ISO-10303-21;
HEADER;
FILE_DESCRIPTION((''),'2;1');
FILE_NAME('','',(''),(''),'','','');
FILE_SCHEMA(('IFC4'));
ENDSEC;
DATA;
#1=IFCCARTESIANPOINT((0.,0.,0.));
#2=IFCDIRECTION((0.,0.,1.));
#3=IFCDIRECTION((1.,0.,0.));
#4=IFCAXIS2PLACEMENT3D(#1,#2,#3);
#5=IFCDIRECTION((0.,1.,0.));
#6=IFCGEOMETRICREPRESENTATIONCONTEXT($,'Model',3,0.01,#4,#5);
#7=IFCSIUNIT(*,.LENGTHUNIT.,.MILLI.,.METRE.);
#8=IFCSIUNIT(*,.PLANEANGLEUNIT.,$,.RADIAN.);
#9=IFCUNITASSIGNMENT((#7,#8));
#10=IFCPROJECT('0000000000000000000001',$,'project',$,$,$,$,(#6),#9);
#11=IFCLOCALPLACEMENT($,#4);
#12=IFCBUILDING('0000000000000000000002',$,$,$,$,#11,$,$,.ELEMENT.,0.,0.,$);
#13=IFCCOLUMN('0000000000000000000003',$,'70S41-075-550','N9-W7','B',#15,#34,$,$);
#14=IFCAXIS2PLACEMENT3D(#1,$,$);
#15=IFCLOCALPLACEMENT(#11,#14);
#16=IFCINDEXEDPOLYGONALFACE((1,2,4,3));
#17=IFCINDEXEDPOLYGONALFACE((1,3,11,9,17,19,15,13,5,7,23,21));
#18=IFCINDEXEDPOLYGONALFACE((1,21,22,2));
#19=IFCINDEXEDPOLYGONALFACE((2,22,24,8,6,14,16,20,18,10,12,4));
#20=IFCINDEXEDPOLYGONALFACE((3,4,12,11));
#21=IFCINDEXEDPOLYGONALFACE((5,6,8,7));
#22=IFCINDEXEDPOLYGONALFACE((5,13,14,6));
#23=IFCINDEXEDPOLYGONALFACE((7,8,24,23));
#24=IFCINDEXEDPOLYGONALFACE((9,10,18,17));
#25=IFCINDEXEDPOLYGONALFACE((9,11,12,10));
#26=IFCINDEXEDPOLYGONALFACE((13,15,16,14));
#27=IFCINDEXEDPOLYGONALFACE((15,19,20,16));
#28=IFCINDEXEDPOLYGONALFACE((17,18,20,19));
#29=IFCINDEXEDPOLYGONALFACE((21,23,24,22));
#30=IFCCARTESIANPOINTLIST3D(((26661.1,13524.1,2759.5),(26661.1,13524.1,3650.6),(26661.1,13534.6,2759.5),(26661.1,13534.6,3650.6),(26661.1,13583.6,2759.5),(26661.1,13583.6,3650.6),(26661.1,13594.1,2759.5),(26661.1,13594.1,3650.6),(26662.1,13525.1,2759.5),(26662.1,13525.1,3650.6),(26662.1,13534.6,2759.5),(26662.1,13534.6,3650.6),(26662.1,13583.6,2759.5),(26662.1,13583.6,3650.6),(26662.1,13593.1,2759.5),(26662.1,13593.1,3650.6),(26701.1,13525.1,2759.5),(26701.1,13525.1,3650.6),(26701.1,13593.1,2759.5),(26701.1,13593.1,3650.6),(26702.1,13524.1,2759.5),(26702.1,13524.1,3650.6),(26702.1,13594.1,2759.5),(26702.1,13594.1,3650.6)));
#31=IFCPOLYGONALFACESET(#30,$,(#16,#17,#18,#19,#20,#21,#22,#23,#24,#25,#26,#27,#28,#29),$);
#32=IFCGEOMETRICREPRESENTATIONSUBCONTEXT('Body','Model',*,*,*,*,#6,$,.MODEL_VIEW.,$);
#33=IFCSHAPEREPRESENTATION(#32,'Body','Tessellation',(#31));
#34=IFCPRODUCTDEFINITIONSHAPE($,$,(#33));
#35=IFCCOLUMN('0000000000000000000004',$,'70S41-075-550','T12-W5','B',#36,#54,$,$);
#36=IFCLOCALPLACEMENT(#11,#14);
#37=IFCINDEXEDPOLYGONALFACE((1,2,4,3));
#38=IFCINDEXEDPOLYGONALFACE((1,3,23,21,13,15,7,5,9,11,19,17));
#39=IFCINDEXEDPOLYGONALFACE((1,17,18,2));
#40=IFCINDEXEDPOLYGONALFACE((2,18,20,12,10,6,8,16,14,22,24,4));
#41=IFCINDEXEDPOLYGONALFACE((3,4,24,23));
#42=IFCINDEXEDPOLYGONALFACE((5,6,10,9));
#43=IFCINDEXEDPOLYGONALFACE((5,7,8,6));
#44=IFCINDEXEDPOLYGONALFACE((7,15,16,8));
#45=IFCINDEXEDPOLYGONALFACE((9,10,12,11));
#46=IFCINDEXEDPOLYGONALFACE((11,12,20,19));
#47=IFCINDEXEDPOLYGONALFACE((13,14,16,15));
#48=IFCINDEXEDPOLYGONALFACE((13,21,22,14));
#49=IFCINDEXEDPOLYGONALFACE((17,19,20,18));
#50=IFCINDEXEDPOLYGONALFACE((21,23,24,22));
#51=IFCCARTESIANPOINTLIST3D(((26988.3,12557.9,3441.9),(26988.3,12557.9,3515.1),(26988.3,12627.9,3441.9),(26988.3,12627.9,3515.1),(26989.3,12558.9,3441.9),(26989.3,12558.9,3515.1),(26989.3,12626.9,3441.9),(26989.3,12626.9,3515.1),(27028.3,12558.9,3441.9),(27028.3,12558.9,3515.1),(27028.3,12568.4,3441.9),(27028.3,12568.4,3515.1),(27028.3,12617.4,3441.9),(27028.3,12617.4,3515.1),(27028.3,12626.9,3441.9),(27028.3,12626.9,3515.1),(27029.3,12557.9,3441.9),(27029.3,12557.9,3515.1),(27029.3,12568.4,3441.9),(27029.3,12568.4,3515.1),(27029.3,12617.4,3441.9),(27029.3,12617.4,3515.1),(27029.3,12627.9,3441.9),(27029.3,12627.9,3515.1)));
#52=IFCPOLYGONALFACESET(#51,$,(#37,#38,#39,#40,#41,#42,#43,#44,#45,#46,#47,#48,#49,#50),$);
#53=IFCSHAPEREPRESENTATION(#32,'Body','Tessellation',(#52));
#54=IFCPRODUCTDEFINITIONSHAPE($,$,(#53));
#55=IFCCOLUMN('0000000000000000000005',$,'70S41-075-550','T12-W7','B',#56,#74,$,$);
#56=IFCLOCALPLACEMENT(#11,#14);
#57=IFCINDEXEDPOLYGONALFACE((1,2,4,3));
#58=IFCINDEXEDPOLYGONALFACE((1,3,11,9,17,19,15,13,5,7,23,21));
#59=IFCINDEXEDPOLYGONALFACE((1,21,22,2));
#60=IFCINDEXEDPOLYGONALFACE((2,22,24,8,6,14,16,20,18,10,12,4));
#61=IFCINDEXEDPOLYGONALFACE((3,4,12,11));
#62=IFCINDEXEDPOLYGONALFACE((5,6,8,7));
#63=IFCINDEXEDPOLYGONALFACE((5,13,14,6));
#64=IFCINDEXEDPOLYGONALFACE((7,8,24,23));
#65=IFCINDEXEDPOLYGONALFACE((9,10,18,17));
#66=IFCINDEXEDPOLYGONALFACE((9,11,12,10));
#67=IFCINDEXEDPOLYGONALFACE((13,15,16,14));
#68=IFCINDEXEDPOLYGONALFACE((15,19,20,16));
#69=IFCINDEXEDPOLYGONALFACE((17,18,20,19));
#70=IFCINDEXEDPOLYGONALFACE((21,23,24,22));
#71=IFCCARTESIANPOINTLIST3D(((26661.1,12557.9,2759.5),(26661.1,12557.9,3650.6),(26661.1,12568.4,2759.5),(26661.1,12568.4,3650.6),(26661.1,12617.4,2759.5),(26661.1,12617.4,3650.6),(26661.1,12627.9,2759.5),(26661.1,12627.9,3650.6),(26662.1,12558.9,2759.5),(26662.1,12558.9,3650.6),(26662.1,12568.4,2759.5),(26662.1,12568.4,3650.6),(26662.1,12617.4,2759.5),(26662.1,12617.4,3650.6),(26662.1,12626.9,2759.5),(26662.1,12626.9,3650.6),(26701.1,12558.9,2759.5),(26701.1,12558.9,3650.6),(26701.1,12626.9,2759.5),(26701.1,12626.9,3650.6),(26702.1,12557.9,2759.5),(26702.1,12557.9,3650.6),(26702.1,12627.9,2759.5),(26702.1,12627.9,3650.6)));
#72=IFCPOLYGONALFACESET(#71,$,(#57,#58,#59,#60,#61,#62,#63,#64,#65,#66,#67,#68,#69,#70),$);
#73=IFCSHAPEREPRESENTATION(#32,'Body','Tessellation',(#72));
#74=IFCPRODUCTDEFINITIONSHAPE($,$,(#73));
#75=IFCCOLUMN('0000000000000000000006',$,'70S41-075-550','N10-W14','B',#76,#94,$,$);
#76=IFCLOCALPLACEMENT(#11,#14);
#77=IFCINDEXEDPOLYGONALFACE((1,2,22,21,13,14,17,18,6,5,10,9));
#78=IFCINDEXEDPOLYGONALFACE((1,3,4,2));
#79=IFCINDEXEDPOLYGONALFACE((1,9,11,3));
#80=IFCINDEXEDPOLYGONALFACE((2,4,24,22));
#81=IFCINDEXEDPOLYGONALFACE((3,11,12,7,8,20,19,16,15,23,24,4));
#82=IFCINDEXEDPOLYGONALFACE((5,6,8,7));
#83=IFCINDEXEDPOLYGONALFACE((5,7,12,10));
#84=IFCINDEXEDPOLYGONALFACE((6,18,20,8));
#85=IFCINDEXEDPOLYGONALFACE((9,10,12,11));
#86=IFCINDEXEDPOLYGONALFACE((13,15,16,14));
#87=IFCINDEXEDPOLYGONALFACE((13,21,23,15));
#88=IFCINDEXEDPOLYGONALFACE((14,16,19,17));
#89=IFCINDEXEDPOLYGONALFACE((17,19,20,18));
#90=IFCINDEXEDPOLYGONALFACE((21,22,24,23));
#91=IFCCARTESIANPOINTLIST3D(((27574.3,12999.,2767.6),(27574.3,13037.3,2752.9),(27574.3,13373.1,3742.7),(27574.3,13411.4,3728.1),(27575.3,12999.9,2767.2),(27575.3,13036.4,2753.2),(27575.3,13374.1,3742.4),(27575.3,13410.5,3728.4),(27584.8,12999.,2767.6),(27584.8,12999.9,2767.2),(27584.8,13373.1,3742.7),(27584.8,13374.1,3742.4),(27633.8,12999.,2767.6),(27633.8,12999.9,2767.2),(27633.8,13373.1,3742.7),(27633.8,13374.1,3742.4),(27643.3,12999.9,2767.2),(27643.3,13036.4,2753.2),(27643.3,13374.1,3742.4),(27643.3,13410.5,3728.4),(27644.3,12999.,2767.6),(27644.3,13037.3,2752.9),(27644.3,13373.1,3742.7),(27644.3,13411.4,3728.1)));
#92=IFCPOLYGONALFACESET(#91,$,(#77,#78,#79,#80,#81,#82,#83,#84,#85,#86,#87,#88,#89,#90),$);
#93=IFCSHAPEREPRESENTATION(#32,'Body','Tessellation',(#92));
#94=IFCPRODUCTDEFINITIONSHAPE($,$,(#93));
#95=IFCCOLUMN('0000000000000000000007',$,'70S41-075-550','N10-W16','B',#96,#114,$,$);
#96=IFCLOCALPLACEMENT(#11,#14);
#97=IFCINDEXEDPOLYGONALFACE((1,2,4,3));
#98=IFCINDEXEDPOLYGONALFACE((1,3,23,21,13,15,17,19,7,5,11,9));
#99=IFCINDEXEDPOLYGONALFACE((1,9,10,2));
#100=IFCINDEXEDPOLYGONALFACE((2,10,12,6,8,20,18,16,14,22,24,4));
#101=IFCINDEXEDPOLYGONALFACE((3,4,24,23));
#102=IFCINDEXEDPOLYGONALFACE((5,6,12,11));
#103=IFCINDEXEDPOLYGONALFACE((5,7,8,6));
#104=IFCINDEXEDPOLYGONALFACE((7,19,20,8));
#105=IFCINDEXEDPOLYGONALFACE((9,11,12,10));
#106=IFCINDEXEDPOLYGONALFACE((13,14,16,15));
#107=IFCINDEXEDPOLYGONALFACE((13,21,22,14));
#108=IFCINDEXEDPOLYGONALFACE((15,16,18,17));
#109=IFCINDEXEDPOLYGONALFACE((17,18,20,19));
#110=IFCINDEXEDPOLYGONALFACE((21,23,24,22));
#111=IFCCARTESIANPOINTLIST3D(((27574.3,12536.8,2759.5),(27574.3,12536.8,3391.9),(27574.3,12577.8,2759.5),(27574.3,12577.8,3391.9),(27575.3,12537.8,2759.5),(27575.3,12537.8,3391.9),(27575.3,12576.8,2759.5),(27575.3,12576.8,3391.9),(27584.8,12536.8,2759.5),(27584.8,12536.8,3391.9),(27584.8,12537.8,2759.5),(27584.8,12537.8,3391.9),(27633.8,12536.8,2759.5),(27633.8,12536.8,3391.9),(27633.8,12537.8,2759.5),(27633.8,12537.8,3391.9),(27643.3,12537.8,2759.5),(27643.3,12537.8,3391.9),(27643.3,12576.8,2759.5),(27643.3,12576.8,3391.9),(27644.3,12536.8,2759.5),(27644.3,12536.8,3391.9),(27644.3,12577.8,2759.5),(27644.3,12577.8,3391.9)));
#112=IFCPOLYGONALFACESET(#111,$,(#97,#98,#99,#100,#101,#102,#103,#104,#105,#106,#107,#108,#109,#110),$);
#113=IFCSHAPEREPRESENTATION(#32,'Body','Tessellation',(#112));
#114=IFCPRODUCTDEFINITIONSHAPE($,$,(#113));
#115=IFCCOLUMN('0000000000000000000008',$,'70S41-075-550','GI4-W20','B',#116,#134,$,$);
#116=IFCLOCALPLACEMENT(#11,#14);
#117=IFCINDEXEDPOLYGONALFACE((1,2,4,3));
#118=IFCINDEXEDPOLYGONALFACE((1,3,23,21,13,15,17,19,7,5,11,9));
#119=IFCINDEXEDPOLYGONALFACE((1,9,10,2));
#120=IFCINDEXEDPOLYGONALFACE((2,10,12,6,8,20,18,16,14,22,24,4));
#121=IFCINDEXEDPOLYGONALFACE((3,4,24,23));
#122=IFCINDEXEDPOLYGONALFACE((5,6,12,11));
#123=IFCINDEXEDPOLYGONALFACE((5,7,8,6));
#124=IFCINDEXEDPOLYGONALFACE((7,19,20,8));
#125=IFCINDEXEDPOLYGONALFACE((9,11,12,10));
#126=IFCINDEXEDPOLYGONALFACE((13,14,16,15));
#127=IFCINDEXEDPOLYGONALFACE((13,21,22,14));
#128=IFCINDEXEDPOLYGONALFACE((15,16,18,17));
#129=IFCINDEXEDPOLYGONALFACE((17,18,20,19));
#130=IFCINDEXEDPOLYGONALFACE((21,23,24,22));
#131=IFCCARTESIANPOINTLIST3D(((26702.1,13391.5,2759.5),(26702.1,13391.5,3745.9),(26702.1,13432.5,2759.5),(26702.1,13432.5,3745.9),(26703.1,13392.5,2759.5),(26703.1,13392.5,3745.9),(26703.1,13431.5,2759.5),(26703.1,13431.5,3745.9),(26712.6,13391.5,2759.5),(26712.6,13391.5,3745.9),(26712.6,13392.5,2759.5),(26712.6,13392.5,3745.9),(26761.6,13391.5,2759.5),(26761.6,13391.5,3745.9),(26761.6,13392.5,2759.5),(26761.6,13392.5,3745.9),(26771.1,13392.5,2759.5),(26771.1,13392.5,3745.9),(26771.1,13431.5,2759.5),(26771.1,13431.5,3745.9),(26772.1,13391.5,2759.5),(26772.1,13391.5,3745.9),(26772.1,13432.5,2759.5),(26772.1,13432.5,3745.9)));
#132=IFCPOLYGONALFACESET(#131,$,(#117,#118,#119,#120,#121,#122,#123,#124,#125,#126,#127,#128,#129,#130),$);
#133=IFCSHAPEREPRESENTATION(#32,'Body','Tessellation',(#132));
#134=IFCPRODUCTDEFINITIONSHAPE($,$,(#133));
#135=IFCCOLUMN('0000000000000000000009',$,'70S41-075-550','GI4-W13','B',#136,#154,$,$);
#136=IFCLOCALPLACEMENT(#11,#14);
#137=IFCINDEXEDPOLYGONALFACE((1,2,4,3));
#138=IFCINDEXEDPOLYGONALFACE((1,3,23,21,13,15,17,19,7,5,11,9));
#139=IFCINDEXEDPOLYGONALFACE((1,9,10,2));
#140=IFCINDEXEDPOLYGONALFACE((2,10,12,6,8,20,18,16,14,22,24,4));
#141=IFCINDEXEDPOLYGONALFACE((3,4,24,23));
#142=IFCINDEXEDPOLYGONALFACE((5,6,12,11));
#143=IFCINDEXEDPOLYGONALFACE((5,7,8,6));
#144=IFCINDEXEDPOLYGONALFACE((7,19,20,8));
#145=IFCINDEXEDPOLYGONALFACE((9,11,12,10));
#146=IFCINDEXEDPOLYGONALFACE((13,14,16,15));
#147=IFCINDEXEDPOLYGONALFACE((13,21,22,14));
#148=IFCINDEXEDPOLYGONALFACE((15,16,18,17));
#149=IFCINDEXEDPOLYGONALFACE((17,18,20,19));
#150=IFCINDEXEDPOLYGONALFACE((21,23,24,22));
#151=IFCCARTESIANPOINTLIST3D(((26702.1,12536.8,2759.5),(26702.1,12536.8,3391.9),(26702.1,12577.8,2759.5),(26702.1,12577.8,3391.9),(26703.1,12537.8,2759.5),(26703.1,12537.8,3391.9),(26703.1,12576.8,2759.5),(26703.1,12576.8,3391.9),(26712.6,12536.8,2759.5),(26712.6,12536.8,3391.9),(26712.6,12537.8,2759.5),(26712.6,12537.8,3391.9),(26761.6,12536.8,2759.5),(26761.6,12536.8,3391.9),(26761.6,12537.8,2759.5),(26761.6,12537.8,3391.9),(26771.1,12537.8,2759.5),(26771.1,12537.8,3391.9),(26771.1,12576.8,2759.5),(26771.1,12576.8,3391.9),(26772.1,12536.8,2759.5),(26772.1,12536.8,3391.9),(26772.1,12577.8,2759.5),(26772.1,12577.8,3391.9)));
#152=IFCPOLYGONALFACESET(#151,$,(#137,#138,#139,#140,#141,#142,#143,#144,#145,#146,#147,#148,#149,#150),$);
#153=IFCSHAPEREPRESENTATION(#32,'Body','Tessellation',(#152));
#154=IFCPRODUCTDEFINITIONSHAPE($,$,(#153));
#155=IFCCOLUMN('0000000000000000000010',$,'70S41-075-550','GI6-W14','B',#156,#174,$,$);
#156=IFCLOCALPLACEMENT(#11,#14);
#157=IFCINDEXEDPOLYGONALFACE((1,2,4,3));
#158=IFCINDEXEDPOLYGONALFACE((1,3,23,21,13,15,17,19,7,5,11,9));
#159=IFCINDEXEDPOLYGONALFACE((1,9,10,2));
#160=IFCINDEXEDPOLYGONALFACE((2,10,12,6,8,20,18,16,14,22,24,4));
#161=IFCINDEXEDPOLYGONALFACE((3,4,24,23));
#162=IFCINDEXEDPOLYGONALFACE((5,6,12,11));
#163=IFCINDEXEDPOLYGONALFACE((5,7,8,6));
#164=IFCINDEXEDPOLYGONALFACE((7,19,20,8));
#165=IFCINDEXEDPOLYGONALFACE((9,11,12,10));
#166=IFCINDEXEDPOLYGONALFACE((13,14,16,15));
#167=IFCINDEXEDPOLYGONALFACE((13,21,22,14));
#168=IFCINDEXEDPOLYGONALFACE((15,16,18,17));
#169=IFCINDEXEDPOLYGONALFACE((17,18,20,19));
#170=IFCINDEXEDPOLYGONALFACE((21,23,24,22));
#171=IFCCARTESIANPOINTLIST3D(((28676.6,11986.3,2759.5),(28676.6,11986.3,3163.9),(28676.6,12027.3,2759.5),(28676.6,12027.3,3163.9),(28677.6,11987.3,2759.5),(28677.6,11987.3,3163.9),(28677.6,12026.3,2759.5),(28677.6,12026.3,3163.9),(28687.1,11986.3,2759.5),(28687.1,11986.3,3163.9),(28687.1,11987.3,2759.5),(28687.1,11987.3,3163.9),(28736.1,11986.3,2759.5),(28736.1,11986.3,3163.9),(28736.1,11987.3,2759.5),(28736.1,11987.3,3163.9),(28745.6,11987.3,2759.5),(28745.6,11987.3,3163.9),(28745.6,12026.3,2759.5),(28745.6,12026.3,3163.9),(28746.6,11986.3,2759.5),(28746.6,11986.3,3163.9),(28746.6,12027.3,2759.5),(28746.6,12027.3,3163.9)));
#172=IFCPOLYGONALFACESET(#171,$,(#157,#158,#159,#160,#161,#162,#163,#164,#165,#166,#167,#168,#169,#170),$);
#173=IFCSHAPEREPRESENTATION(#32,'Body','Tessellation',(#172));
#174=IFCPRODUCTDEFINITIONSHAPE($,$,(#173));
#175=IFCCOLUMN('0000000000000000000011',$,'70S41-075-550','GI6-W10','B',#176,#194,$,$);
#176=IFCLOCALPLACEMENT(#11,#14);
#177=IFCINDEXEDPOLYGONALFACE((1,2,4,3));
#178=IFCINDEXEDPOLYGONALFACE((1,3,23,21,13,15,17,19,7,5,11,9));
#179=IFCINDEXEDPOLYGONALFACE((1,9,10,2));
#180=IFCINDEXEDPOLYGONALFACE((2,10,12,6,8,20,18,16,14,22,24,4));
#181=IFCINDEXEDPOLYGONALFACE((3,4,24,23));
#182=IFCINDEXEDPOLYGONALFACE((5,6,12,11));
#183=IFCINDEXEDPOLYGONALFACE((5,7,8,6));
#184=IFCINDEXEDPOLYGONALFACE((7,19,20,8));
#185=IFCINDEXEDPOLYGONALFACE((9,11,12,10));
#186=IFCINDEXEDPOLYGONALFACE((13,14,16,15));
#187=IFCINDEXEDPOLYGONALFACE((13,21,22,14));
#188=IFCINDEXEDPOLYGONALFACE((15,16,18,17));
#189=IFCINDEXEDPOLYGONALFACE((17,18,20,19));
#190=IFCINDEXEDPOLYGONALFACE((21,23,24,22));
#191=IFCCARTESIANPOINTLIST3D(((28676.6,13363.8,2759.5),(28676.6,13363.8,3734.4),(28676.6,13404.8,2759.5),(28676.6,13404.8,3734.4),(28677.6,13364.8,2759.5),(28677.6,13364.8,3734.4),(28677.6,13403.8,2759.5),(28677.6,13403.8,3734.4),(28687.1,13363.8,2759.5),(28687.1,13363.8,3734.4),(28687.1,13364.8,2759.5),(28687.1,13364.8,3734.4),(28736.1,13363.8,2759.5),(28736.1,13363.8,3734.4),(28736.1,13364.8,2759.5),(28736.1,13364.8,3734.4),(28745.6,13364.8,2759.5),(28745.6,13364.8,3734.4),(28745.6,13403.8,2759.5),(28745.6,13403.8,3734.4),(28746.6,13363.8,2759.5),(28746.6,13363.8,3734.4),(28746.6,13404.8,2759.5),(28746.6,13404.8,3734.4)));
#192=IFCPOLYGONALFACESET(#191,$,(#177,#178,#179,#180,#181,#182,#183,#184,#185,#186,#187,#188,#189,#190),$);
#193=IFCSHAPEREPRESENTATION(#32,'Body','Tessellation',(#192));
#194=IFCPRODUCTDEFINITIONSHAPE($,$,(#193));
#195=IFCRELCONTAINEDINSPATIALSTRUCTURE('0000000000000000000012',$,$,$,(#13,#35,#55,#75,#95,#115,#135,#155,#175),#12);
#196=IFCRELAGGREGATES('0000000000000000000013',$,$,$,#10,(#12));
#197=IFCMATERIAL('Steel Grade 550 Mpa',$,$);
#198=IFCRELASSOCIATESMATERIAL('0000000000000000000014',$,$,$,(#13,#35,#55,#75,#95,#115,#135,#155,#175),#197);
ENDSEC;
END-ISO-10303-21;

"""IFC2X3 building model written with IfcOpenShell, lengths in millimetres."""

from ifc_helpers import new_model, si_unit, direction, frame, origin, origin_with_axes, origin_2d_with_axis, place, context, subcontext, project, spatial, c_section, extrude, source, transform, mapped, material, element, save


model = new_model("IFC2X3")

# Units and contexts
model_context = context("Model", 3, precision=0.01, world=origin_with_axes(), true_north=direction((0.0, 1.0, 0.0)))
body_context = subcontext(model_context, "Body", "Model", "MODEL_VIEW")
ifc_project = project(units=[si_unit("LENGTHUNIT", "METRE", prefix="MILLI"), si_unit("PLANEANGLEUNIT", "RADIAN")], contexts=[model_context])

# Building
building_placement = place(None, origin_with_axes())
building = spatial("IfcBuilding", under=ifc_project, at=building_placement, CompositionType="ELEMENT", ElevationOfRefHeight=0.0, ElevationOfTerrain=0.0)

# Columns
ifc_material = material(Name="Steel Grade 550 Mpa")
shared_shape_1 = source(origin(), body_context, "Body", "SweptSolid", [
    extrude(c_section(Depth=70.0, Width=41.0, WallThickness=1.0, Girth=10.5, at=origin_2d_with_axis()), origin_with_axes(), (0.0, 0.0, 1.0), 891.1),
])
column_1_placement = place(None, frame((26681.6, 13559.1, 3650.6), z_axis=(0.0, 0.0, -1.0), x_axis=(-1.0, 0.0, 0.0)))
element("IfcColumn", 1, at=column_1_placement, inside=building, material=ifc_material, Name="70S41-075-550", Description="N9-W7", ObjectType="B", context=body_context, shape_type="MappedRepresentation", body=[
    mapped(shared_shape_1, transform((0.0, 0.0, 0.0), scale=1.0)),
])
shared_shape_2 = source(origin(), body_context, "Body", "SweptSolid", [
    extrude(c_section(Depth=70.0, Width=41.0, WallThickness=1.0, Girth=10.5, at=origin_2d_with_axis()), origin_with_axes(), (0.0, 0.0, 1.0), 73.2),
])
column_2_placement = place(None, frame((27008.8, 12592.9, 3441.9), z_axis=(0.0, 0.0, 1.0), x_axis=(1.0, 0.0, 0.0)))
element("IfcColumn", 2, at=column_2_placement, inside=building, material=ifc_material, Name="70S41-075-550", Description="T12-W5", ObjectType="B", context=body_context, shape_type="MappedRepresentation", body=[
    mapped(shared_shape_2, transform((0.0, 0.0, 0.0), scale=1.0)),
])
shared_shape_3 = source(origin(), body_context, "Body", "SweptSolid", [
    extrude(c_section(Depth=70.0, Width=41.0, WallThickness=1.0, Girth=10.5, at=origin_2d_with_axis()), origin_with_axes(), (0.0, 0.0, 1.0), 891.1),
])
column_3_placement = place(None, frame((26681.6, 12592.9, 3650.6), z_axis=(0.0, 0.0, -1.0), x_axis=(-1.0, 0.0, 0.0)))
element("IfcColumn", 3, at=column_3_placement, inside=building, material=ifc_material, Name="70S41-075-550", Description="T12-W7", ObjectType="B", context=body_context, shape_type="MappedRepresentation", body=[
    mapped(shared_shape_3, transform((0.0, 0.0, 0.0), scale=1.0)),
])
shared_shape_4 = source(origin(), body_context, "Body", "SweptSolid", [
    extrude(c_section(Depth=70.0, Width=41.0, WallThickness=1.0, Girth=10.5, at=origin_2d_with_axis()), origin_with_axes(), (0.0, 0.0, 1.0), 1044.5),
])
column_4_placement = place(None, frame((27609.3, 13392.3, 3735.4), z_axis=(0.0, -0.358188, -0.933649), x_axis=(0.0, -0.933649, 0.358188)))
element("IfcColumn", 4, at=column_4_placement, inside=building, material=ifc_material, Name="70S41-075-550", Description="N10-W14", ObjectType="B", context=body_context, shape_type="MappedRepresentation", body=[
    mapped(shared_shape_4, transform((0.0, 0.0, 0.0), scale=1.0)),
])
shared_shape_5 = source(origin(), body_context, "Body", "SweptSolid", [
    extrude(c_section(Depth=70.0, Width=41.0, WallThickness=1.0, Girth=10.5, at=origin_2d_with_axis()), origin_with_axes(), (0.0, 0.0, 1.0), 632.4),
])
column_5_placement = place(None, frame((27609.3, 12557.3, 3391.9), z_axis=(0.0, 0.0, -1.0), x_axis=(0.0, -1.0, 0.0)))
element("IfcColumn", 5, at=column_5_placement, inside=building, material=ifc_material, Name="70S41-075-550", Description="N10-W16", ObjectType="B", context=body_context, shape_type="MappedRepresentation", body=[
    mapped(shared_shape_5, transform((0.0, 0.0, 0.0), scale=1.0)),
])
shared_shape_6 = source(origin(), body_context, "Body", "SweptSolid", [
    extrude(c_section(Depth=70.0, Width=41.0, WallThickness=1.0, Girth=10.5, at=origin_2d_with_axis()), origin_with_axes(), (0.0, 0.0, 1.0), 986.4),
])
column_6_placement = place(None, frame((26737.1, 13412.0, 3745.9), z_axis=(0.0, 0.0, -1.0), x_axis=(0.0, -1.0, 0.0)))
element("IfcColumn", 6, at=column_6_placement, inside=building, material=ifc_material, Name="70S41-075-550", Description="GI4-W20", ObjectType="B", context=body_context, shape_type="MappedRepresentation", body=[
    mapped(shared_shape_6, transform((0.0, 0.0, 0.0), scale=1.0)),
])
shared_shape_7 = source(origin(), body_context, "Body", "SweptSolid", [
    extrude(c_section(Depth=70.0, Width=41.0, WallThickness=1.0, Girth=10.5, at=origin_2d_with_axis()), origin_with_axes(), (0.0, 0.0, 1.0), 632.4),
])
column_7_placement = place(None, frame((26737.1, 12557.3, 3391.9), z_axis=(0.0, 0.0, -1.0), x_axis=(0.0, -1.0, 0.0)))
element("IfcColumn", 7, at=column_7_placement, inside=building, material=ifc_material, Name="70S41-075-550", Description="GI4-W13", ObjectType="B", context=body_context, shape_type="MappedRepresentation", body=[
    mapped(shared_shape_7, transform((0.0, 0.0, 0.0), scale=1.0)),
])
shared_shape_8 = source(origin(), body_context, "Body", "SweptSolid", [
    extrude(c_section(Depth=70.0, Width=41.0, WallThickness=1.0, Girth=10.5, at=origin_2d_with_axis()), origin_with_axes(), (0.0, 0.0, 1.0), 404.4),
])
column_8_placement = place(None, frame((28711.6, 12006.8, 3163.9), z_axis=(0.0, 0.0, -1.0), x_axis=(0.0, -1.0, 0.0)))
element("IfcColumn", 8, at=column_8_placement, inside=building, material=ifc_material, Name="70S41-075-550", Description="GI6-W14", ObjectType="B", context=body_context, shape_type="MappedRepresentation", body=[
    mapped(shared_shape_8, transform((0.0, 0.0, 0.0), scale=1.0)),
])
shared_shape_9 = source(origin(), body_context, "Body", "SweptSolid", [
    extrude(c_section(Depth=70.0, Width=41.0, WallThickness=1.0, Girth=10.5, at=origin_2d_with_axis()), origin_with_axes(), (0.0, 0.0, 1.0), 974.9),
])
column_9_placement = place(None, frame((28711.6, 13384.3, 3734.4), z_axis=(0.0, 0.0, -1.0), x_axis=(0.0, -1.0, 0.0)))
element("IfcColumn", 9, at=column_9_placement, inside=building, material=ifc_material, Name="70S41-075-550", Description="GI6-W10", ObjectType="B", context=body_context, shape_type="MappedRepresentation", body=[
    mapped(shared_shape_9, transform((0.0, 0.0, 0.0), scale=1.0)),
])

save(model, "model.ifc")
